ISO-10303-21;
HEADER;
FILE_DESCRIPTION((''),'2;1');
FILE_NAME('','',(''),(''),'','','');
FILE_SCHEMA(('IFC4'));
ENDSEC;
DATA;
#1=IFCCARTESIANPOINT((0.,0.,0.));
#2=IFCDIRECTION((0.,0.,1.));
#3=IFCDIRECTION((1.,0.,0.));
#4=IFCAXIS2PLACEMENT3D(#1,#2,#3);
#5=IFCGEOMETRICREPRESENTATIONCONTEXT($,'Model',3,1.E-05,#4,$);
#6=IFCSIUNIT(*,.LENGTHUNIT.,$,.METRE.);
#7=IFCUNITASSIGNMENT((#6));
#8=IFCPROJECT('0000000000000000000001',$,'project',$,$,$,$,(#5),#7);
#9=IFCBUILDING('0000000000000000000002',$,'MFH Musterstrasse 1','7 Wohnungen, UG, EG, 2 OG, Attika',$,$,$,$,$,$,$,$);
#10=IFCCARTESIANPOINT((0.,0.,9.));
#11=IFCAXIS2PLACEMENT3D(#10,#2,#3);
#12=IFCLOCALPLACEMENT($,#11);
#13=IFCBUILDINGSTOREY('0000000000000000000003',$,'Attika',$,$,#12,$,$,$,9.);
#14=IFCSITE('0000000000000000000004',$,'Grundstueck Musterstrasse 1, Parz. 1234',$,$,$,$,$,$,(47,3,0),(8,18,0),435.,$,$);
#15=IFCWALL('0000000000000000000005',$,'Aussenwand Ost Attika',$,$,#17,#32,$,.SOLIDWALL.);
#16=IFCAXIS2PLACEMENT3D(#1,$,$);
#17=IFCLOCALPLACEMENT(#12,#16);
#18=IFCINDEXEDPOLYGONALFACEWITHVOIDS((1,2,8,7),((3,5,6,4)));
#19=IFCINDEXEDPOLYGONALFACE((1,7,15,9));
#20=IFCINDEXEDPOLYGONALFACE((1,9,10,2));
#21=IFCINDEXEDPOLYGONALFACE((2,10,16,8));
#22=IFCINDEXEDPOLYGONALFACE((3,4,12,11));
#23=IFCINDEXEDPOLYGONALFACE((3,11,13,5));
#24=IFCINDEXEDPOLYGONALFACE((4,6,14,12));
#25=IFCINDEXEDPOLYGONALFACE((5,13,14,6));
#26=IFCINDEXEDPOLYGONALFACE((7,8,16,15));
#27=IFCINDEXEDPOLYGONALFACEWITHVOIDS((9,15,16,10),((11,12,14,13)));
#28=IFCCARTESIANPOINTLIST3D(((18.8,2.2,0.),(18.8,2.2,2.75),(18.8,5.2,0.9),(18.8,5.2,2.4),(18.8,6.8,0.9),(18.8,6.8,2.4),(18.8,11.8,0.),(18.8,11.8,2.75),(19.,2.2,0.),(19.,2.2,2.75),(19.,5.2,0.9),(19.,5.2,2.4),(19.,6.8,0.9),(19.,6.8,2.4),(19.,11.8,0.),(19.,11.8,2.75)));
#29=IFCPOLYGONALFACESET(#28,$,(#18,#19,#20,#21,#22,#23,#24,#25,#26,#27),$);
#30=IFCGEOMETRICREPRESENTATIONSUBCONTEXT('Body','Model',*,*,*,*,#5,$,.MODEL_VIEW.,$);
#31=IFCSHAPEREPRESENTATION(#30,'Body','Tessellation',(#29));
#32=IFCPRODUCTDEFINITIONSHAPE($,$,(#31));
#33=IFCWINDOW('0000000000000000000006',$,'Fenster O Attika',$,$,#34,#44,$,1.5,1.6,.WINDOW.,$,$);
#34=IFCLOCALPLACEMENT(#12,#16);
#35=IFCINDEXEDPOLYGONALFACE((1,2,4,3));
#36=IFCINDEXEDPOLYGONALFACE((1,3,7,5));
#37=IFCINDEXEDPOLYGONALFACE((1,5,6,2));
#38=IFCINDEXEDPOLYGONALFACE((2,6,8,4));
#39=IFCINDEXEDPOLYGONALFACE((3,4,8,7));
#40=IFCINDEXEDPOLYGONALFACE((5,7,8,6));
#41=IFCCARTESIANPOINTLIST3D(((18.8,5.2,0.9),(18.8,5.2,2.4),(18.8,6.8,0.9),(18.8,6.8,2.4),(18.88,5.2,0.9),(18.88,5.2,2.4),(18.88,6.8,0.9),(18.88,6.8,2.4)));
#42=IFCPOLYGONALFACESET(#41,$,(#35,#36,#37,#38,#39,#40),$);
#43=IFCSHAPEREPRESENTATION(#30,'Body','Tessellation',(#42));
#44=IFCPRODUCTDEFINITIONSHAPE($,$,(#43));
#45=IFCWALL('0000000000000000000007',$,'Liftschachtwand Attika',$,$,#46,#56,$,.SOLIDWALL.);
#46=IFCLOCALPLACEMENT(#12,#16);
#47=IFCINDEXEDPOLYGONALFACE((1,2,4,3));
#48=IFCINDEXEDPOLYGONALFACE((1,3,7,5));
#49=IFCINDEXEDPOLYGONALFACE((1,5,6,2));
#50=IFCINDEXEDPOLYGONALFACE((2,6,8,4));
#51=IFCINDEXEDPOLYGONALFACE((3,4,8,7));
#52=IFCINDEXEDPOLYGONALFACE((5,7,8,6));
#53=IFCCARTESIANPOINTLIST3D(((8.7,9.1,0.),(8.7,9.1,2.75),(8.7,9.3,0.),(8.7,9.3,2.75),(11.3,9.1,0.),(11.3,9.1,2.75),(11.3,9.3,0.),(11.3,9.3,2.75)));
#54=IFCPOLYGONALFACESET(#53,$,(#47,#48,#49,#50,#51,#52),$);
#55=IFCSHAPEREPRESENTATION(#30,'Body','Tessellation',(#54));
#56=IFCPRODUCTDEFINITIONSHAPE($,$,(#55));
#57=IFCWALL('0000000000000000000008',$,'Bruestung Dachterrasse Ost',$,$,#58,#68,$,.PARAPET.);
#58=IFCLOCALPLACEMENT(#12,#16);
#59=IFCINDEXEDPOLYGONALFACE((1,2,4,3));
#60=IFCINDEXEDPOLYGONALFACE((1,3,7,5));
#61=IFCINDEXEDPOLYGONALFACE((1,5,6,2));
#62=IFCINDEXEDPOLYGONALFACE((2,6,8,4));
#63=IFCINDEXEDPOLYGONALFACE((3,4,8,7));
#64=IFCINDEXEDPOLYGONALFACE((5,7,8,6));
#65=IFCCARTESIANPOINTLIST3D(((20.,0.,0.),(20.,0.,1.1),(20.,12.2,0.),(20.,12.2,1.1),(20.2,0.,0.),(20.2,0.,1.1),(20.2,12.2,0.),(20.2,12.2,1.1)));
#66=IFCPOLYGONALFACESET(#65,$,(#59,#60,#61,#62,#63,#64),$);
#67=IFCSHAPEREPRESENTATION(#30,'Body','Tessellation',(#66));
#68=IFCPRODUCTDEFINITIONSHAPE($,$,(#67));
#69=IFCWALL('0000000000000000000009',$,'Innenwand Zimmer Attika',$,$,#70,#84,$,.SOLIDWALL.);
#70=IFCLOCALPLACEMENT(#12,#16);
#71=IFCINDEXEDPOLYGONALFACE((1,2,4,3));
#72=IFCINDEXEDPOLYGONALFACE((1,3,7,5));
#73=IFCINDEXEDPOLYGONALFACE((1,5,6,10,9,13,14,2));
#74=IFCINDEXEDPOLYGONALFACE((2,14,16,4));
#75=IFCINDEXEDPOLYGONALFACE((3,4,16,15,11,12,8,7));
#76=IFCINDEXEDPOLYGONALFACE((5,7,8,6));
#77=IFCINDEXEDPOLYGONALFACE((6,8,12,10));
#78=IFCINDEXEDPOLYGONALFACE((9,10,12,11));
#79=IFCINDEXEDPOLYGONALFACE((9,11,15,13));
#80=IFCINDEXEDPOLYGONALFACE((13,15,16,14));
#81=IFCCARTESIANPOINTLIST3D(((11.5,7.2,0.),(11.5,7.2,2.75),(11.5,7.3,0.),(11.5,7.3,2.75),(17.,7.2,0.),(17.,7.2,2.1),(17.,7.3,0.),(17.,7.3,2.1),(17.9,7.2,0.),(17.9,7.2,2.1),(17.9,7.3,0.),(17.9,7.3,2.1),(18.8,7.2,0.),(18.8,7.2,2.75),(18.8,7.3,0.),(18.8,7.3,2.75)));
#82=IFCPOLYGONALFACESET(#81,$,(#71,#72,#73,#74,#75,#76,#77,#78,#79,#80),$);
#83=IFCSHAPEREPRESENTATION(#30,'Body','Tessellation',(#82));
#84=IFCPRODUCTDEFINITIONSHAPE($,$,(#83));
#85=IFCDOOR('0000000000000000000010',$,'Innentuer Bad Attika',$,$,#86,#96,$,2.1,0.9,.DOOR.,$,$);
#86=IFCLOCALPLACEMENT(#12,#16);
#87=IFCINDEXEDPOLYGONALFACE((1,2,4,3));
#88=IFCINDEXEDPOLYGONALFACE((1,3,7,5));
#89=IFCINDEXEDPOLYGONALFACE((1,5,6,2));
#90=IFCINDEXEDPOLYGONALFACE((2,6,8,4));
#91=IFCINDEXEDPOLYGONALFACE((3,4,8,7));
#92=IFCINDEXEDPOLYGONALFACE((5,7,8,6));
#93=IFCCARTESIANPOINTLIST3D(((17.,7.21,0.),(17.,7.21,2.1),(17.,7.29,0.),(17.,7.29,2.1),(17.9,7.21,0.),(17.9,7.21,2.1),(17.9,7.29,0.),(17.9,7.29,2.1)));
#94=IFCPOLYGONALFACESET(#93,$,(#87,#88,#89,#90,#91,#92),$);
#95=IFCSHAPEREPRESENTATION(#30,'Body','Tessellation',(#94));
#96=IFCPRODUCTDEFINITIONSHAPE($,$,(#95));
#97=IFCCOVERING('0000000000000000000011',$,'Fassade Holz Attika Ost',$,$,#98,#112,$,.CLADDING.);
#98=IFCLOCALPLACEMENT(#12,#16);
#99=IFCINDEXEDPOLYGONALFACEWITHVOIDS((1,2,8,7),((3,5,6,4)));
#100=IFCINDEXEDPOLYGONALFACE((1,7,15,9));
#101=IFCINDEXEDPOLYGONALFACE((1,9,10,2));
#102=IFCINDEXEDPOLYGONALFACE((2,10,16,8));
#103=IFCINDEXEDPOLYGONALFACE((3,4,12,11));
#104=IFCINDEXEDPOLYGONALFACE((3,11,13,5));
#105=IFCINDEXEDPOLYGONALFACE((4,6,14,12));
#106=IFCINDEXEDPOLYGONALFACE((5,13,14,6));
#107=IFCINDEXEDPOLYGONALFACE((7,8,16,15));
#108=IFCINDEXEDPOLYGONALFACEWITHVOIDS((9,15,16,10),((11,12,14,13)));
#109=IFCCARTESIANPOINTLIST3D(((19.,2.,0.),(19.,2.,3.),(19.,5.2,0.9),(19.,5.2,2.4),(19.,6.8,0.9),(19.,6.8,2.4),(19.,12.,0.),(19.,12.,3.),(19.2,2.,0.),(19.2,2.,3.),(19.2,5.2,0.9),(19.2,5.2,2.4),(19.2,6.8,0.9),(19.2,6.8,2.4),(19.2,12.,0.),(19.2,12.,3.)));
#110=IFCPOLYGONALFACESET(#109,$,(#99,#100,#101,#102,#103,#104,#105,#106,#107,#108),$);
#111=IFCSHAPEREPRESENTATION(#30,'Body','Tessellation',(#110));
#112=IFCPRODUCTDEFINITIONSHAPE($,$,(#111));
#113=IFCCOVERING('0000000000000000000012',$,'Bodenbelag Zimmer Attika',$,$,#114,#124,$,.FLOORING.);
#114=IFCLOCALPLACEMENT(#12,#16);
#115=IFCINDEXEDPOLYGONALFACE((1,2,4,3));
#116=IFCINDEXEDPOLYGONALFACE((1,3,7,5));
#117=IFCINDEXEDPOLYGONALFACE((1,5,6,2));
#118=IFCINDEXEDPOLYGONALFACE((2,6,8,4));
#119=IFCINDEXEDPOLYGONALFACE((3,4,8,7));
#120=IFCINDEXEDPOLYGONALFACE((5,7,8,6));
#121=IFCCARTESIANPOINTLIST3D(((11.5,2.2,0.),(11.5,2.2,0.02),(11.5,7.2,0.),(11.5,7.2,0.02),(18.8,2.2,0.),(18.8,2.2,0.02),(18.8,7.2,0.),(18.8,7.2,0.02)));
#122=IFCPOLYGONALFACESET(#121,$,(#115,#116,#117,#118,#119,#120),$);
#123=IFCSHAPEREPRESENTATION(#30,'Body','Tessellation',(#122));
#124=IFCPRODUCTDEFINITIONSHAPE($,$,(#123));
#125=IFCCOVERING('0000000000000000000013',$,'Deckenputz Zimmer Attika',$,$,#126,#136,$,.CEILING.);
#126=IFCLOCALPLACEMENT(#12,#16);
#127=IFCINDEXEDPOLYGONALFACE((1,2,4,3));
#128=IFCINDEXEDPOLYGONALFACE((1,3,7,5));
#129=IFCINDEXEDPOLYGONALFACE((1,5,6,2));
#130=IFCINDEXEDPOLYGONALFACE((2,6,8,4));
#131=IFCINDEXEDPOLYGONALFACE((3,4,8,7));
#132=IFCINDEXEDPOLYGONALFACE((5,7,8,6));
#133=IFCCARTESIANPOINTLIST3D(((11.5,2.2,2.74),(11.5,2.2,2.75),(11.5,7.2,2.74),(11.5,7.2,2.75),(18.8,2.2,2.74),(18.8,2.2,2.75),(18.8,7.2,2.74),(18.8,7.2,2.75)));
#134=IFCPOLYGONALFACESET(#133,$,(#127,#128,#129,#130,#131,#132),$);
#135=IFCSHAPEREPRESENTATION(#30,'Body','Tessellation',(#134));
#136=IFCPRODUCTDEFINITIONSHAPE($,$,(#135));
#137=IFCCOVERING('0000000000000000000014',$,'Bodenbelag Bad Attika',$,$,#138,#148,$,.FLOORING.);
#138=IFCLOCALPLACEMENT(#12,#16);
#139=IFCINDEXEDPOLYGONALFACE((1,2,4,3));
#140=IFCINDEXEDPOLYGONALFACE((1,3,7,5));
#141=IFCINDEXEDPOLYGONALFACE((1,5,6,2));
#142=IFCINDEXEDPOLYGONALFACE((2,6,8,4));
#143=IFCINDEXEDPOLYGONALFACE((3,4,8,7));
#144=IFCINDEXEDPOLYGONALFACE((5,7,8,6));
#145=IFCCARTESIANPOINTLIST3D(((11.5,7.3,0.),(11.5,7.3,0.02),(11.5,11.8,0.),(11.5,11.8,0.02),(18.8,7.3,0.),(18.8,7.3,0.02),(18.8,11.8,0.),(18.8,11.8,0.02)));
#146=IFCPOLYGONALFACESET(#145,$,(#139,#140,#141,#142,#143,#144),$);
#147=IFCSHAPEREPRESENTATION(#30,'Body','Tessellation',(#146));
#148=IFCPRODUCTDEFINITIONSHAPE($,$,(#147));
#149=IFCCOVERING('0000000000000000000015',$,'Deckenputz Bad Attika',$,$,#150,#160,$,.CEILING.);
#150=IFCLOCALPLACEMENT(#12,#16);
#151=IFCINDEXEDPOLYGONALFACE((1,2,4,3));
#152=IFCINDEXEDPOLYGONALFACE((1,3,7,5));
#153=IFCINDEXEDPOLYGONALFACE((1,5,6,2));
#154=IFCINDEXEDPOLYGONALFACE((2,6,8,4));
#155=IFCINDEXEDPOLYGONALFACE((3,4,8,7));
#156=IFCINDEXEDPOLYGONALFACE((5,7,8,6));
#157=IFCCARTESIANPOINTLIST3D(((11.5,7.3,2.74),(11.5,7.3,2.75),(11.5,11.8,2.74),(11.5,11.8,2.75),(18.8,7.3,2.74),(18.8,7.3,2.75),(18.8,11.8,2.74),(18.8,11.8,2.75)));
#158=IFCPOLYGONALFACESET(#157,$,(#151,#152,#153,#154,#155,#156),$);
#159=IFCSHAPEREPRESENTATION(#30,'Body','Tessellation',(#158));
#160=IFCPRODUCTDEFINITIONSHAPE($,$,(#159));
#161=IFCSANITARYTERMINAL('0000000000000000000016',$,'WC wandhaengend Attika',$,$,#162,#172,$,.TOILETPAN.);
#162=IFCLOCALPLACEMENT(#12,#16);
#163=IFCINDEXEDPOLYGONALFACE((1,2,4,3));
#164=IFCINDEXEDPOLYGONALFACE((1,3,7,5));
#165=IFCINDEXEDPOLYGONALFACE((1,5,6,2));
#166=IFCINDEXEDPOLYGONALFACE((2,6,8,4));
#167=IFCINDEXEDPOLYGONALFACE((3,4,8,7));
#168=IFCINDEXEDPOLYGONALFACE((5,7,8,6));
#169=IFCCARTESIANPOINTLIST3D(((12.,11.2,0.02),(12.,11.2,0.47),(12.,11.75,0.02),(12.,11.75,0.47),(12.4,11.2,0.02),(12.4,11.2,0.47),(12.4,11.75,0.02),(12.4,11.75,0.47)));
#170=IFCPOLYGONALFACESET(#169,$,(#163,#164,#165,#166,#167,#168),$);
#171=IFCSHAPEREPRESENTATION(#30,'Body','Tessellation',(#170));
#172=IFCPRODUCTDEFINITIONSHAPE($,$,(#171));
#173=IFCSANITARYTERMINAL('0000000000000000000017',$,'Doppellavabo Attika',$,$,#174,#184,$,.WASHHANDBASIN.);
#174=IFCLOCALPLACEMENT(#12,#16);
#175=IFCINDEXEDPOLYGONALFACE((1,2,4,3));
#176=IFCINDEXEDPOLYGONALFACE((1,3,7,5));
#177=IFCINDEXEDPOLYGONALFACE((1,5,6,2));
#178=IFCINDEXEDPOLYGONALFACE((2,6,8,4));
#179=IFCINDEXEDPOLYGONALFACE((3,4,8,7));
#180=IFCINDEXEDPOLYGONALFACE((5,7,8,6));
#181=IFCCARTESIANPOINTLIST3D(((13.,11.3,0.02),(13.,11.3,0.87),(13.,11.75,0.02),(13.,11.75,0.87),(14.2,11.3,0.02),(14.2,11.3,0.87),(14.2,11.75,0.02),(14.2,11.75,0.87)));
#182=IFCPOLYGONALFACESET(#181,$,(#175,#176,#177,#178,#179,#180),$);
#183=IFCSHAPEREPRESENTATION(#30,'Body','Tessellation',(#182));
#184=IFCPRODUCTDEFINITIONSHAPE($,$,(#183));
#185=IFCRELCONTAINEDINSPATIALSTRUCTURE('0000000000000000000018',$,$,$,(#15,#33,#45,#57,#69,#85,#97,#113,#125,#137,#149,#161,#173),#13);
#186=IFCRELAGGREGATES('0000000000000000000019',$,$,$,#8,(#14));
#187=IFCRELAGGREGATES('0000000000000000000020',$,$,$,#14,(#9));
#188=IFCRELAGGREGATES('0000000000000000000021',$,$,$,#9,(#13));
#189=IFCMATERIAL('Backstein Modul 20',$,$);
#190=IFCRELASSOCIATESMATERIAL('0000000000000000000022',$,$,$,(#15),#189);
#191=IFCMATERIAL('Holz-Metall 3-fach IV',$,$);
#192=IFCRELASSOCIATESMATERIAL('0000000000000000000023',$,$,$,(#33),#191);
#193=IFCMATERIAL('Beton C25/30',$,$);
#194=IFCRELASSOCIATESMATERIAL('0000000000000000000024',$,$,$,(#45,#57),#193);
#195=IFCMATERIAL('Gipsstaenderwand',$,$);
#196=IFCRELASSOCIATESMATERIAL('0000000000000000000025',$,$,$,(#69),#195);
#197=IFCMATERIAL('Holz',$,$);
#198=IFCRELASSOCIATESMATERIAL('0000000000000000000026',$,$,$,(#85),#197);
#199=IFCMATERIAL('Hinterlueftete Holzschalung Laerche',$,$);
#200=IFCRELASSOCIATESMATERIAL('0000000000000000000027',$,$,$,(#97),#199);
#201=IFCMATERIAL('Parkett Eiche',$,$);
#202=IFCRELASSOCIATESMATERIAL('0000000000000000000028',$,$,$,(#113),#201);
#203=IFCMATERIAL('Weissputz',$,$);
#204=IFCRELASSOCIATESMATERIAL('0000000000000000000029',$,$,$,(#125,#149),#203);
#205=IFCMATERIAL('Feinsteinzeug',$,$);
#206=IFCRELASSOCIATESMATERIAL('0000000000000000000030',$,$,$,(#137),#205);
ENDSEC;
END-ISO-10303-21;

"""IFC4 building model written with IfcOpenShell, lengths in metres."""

from ifc_helpers import new_model, si_unit, frame, frame_2d, origin_with_axes, place, context, subcontext, project, spatial, rectangle, extrude, material, element, fill, save


model = new_model("IFC4")

# Units and contexts
model_context = context("Model", 3, precision=1e-05, world=origin_with_axes())
body_context = subcontext(model_context, "Body", "Model", "MODEL_VIEW")
ifc_project = project(units=[si_unit("LENGTHUNIT", "METRE")], contexts=[model_context])

# Site, building, storey
site = spatial("IfcSite", under=ifc_project, Name="Grundstueck Musterstrasse 1, Parz. 1234", RefLatitude=(47, 3, 0), RefLongitude=(8, 18, 0), RefElevation=435.0)
building = spatial("IfcBuilding", under=site, Name="MFH Musterstrasse 1", Description="7 Wohnungen, UG, EG, 2 OG, Attika")
storey_placement = place(None, frame((0.0, 0.0, 9.0), z_axis=(0.0, 0.0, 1.0), x_axis=(1.0, 0.0, 0.0)))
storey = spatial("IfcBuildingStorey", under=building, at=storey_placement, Name="Attika", Elevation=9.0)

# Wall, opening, window
ifc_material_1 = material(Name="Backstein Modul 20")
wall_1_placement = place(storey_placement, frame((18.8, 2.2, 0.0), z_axis=(0.0, 0.0, 1.0), x_axis=(1.0, 0.0, 0.0)))
wall_1 = element("IfcWall", 1, at=wall_1_placement, inside=storey, material=ifc_material_1, Name="Aussenwand Ost Attika", PredefinedType="SOLIDWALL", context=body_context, shape_type="SweptSolid", body=[
    extrude(rectangle(XDim=0.2, YDim=9.6, at=frame_2d((0.1, 4.8))), origin_with_axes(), (0.0, 0.0, 1.0), 2.75),
])
opening_1_placement = place(wall_1_placement, frame((-0.01, 3.0, 0.9), z_axis=(0.0, 0.0, 1.0), x_axis=(1.0, 0.0, 0.0)))
opening_1 = element("IfcOpeningElement", 2, at=opening_1_placement, cuts=wall_1, context=body_context, shape_type="SweptSolid", body=[
    extrude(rectangle(XDim=0.42, YDim=1.6, at=frame_2d((0.21, 0.8))), origin_with_axes(), (0.0, 0.0, 1.0), 1.5),
])
ifc_material_2 = material(Name="Holz-Metall 3-fach IV")
window_placement = place(storey_placement, frame((18.8, 5.2, 0.9), z_axis=(0.0, 0.0, 1.0), x_axis=(1.0, 0.0, 0.0)))
window = element("IfcWindow", 3, at=window_placement, inside=storey, material=ifc_material_2, Name="Fenster O Attika", OverallHeight=1.5, OverallWidth=1.6, PredefinedType="WINDOW", context=body_context, shape_type="SweptSolid", body=[
    extrude(rectangle(XDim=0.08, YDim=1.6, at=frame_2d((0.04, 0.8))), origin_with_axes(), (0.0, 0.0, 1.0), 1.5),
])
fill(opening_1, window)

# Shared definitions
ifc_material_3 = material(Name="Beton C25/30")
ifc_material_4 = material(Name="Holz")

# Walls
wall_2_placement = place(storey_placement, frame((8.7, 9.1, 0.0), z_axis=(0.0, 0.0, 1.0), x_axis=(1.0, 0.0, 0.0)))
element("IfcWall", 4, at=wall_2_placement, inside=storey, material=ifc_material_3, Name="Liftschachtwand Attika", PredefinedType="SOLIDWALL", context=body_context, shape_type="SweptSolid", body=[
    extrude(rectangle(XDim=2.6, YDim=0.2, at=frame_2d((1.3, 0.1))), origin_with_axes(), (0.0, 0.0, 1.0), 2.75),
])
wall_3_placement = place(storey_placement, frame((20.0, 0.0, 0.0), z_axis=(0.0, 0.0, 1.0), x_axis=(1.0, 0.0, 0.0)))
element("IfcWall", 5, at=wall_3_placement, inside=storey, material=ifc_material_3, Name="Bruestung Dachterrasse Ost", PredefinedType="PARAPET", context=body_context, shape_type="SweptSolid", body=[
    extrude(rectangle(XDim=0.2, YDim=12.2, at=frame_2d((0.1, 6.1))), origin_with_axes(), (0.0, 0.0, 1.0), 1.1),
])

# Wall, opening, door
ifc_material_5 = material(Name="Gipsstaenderwand")
wall_4_placement = place(storey_placement, frame((11.5, 7.2, 0.0), z_axis=(0.0, 0.0, 1.0), x_axis=(1.0, 0.0, 0.0)))
wall_4 = element("IfcWall", 6, at=wall_4_placement, inside=storey, material=ifc_material_5, Name="Innenwand Zimmer Attika", PredefinedType="SOLIDWALL", context=body_context, shape_type="SweptSolid", body=[
    extrude(rectangle(XDim=7.3, YDim=0.1, at=frame_2d((3.65, 0.05))), origin_with_axes(), (0.0, 0.0, 1.0), 2.75),
])
opening_2_placement = place(wall_4_placement, frame((5.5, -0.01, 0.0), z_axis=(0.0, 0.0, 1.0), x_axis=(1.0, 0.0, 0.0)))
opening_2 = element("IfcOpeningElement", 7, at=opening_2_placement, cuts=wall_4, context=body_context, shape_type="SweptSolid", body=[
    extrude(rectangle(XDim=0.9, YDim=0.12, at=frame_2d((0.45, 0.06))), origin_with_axes(), (0.0, 0.0, 1.0), 2.1),
])
door_1_placement = place(storey_placement, frame((17.0, 7.21, 0.0), z_axis=(0.0, 0.0, 1.0), x_axis=(1.0, 0.0, 0.0)))
door_1 = element("IfcDoor", 8, at=door_1_placement, inside=storey, material=ifc_material_4, Name="Innentuer Bad Attika", OverallHeight=2.1, OverallWidth=0.9, PredefinedType="DOOR", context=body_context, shape_type="SweptSolid", body=[
    extrude(rectangle(XDim=0.9, YDim=0.08, at=frame_2d((0.45, 0.04))), origin_with_axes(), (0.0, 0.0, 1.0), 2.1),
])
fill(opening_2, door_1)

# Covering, opening
ifc_material_6 = material(Name="Hinterlueftete Holzschalung Laerche")
covering_1_placement = place(storey_placement, frame((19.0, 2.0, 0.0), z_axis=(0.0, 0.0, 1.0), x_axis=(1.0, 0.0, 0.0)))
covering_1 = element("IfcCovering", 9, at=covering_1_placement, inside=storey, material=ifc_material_6, Name="Fassade Holz Attika Ost", PredefinedType="CLADDING", context=body_context, shape_type="SweptSolid", body=[
    extrude(rectangle(XDim=0.2, YDim=10.0, at=frame_2d((0.1, 5.0))), origin_with_axes(), (0.0, 0.0, 1.0), 3.0),
])
opening_3_placement = place(covering_1_placement, frame((-0.21, 3.2, 0.9), z_axis=(0.0, 0.0, 1.0), x_axis=(1.0, 0.0, 0.0)))
element("IfcOpeningElement", 10, at=opening_3_placement, cuts=covering_1, context=body_context, shape_type="SweptSolid", body=[
    extrude(rectangle(XDim=0.42, YDim=1.6, at=frame_2d((0.21, 0.8))), origin_with_axes(), (0.0, 0.0, 1.0), 1.5),
])

# Coverings
ifc_material_7 = material(Name="Parkett Eiche")
covering_2_placement = place(storey_placement, frame((11.5, 2.2, 0.0), z_axis=(0.0, 0.0, 1.0), x_axis=(1.0, 0.0, 0.0)))
element("IfcCovering", 11, at=covering_2_placement, inside=storey, material=ifc_material_7, Name="Bodenbelag Zimmer Attika", PredefinedType="FLOORING", context=body_context, shape_type="SweptSolid", body=[
    extrude(rectangle(XDim=7.3, YDim=5.0, at=frame_2d((3.65, 2.5))), origin_with_axes(), (0.0, 0.0, 1.0), 0.02),
])
ifc_material_8 = material(Name="Weissputz")
covering_3_placement = place(storey_placement, frame((11.5, 2.2, 2.74), z_axis=(0.0, 0.0, 1.0), x_axis=(1.0, 0.0, 0.0)))
element("IfcCovering", 12, at=covering_3_placement, inside=storey, material=ifc_material_8, Name="Deckenputz Zimmer Attika", PredefinedType="CEILING", context=body_context, shape_type="SweptSolid", body=[
    extrude(rectangle(XDim=7.3, YDim=5.0, at=frame_2d((3.65, 2.5))), origin_with_axes(), (0.0, 0.0, 1.0), 0.01),
])
ifc_material_9 = material(Name="Feinsteinzeug")
covering_4_placement = place(storey_placement, frame((11.5, 7.3, 0.0), z_axis=(0.0, 0.0, 1.0), x_axis=(1.0, 0.0, 0.0)))
element("IfcCovering", 13, at=covering_4_placement, inside=storey, material=ifc_material_9, Name="Bodenbelag Bad Attika", PredefinedType="FLOORING", context=body_context, shape_type="SweptSolid", body=[
    extrude(rectangle(XDim=7.3, YDim=4.5, at=frame_2d((3.65, 2.25))), origin_with_axes(), (0.0, 0.0, 1.0), 0.02),
])
covering_5_placement = place(storey_placement, frame((11.5, 7.3, 2.74), z_axis=(0.0, 0.0, 1.0), x_axis=(1.0, 0.0, 0.0)))
element("IfcCovering", 14, at=covering_5_placement, inside=storey, material=ifc_material_8, Name="Deckenputz Bad Attika", PredefinedType="CEILING", context=body_context, shape_type="SweptSolid", body=[
    extrude(rectangle(XDim=7.3, YDim=4.5, at=frame_2d((3.65, 2.25))), origin_with_axes(), (0.0, 0.0, 1.0), 0.01),
])

# Sanitary terminals
sanitary_terminal_1_placement = place(storey_placement, frame((12.0, 11.2, 0.02), z_axis=(0.0, 0.0, 1.0), x_axis=(1.0, 0.0, 0.0)))
element("IfcSanitaryTerminal", 15, at=sanitary_terminal_1_placement, inside=storey, Name="WC wandhaengend Attika", PredefinedType="TOILETPAN", context=body_context, shape_type="SweptSolid", body=[
    extrude(rectangle(XDim=0.4, YDim=0.55, at=frame_2d((0.2, 0.275))), origin_with_axes(), (0.0, 0.0, 1.0), 0.45),
])
sanitary_terminal_2_placement = place(storey_placement, frame((13.0, 11.3, 0.02), z_axis=(0.0, 0.0, 1.0), x_axis=(1.0, 0.0, 0.0)))
element("IfcSanitaryTerminal", 16, at=sanitary_terminal_2_placement, inside=storey, Name="Doppellavabo Attika", PredefinedType="WASHHANDBASIN", context=body_context, shape_type="SweptSolid", body=[
    extrude(rectangle(XDim=1.2, YDim=0.45, at=frame_2d((0.6, 0.225))), origin_with_axes(), (0.0, 0.0, 1.0), 0.85),
])

save(model, "model.ifc")
